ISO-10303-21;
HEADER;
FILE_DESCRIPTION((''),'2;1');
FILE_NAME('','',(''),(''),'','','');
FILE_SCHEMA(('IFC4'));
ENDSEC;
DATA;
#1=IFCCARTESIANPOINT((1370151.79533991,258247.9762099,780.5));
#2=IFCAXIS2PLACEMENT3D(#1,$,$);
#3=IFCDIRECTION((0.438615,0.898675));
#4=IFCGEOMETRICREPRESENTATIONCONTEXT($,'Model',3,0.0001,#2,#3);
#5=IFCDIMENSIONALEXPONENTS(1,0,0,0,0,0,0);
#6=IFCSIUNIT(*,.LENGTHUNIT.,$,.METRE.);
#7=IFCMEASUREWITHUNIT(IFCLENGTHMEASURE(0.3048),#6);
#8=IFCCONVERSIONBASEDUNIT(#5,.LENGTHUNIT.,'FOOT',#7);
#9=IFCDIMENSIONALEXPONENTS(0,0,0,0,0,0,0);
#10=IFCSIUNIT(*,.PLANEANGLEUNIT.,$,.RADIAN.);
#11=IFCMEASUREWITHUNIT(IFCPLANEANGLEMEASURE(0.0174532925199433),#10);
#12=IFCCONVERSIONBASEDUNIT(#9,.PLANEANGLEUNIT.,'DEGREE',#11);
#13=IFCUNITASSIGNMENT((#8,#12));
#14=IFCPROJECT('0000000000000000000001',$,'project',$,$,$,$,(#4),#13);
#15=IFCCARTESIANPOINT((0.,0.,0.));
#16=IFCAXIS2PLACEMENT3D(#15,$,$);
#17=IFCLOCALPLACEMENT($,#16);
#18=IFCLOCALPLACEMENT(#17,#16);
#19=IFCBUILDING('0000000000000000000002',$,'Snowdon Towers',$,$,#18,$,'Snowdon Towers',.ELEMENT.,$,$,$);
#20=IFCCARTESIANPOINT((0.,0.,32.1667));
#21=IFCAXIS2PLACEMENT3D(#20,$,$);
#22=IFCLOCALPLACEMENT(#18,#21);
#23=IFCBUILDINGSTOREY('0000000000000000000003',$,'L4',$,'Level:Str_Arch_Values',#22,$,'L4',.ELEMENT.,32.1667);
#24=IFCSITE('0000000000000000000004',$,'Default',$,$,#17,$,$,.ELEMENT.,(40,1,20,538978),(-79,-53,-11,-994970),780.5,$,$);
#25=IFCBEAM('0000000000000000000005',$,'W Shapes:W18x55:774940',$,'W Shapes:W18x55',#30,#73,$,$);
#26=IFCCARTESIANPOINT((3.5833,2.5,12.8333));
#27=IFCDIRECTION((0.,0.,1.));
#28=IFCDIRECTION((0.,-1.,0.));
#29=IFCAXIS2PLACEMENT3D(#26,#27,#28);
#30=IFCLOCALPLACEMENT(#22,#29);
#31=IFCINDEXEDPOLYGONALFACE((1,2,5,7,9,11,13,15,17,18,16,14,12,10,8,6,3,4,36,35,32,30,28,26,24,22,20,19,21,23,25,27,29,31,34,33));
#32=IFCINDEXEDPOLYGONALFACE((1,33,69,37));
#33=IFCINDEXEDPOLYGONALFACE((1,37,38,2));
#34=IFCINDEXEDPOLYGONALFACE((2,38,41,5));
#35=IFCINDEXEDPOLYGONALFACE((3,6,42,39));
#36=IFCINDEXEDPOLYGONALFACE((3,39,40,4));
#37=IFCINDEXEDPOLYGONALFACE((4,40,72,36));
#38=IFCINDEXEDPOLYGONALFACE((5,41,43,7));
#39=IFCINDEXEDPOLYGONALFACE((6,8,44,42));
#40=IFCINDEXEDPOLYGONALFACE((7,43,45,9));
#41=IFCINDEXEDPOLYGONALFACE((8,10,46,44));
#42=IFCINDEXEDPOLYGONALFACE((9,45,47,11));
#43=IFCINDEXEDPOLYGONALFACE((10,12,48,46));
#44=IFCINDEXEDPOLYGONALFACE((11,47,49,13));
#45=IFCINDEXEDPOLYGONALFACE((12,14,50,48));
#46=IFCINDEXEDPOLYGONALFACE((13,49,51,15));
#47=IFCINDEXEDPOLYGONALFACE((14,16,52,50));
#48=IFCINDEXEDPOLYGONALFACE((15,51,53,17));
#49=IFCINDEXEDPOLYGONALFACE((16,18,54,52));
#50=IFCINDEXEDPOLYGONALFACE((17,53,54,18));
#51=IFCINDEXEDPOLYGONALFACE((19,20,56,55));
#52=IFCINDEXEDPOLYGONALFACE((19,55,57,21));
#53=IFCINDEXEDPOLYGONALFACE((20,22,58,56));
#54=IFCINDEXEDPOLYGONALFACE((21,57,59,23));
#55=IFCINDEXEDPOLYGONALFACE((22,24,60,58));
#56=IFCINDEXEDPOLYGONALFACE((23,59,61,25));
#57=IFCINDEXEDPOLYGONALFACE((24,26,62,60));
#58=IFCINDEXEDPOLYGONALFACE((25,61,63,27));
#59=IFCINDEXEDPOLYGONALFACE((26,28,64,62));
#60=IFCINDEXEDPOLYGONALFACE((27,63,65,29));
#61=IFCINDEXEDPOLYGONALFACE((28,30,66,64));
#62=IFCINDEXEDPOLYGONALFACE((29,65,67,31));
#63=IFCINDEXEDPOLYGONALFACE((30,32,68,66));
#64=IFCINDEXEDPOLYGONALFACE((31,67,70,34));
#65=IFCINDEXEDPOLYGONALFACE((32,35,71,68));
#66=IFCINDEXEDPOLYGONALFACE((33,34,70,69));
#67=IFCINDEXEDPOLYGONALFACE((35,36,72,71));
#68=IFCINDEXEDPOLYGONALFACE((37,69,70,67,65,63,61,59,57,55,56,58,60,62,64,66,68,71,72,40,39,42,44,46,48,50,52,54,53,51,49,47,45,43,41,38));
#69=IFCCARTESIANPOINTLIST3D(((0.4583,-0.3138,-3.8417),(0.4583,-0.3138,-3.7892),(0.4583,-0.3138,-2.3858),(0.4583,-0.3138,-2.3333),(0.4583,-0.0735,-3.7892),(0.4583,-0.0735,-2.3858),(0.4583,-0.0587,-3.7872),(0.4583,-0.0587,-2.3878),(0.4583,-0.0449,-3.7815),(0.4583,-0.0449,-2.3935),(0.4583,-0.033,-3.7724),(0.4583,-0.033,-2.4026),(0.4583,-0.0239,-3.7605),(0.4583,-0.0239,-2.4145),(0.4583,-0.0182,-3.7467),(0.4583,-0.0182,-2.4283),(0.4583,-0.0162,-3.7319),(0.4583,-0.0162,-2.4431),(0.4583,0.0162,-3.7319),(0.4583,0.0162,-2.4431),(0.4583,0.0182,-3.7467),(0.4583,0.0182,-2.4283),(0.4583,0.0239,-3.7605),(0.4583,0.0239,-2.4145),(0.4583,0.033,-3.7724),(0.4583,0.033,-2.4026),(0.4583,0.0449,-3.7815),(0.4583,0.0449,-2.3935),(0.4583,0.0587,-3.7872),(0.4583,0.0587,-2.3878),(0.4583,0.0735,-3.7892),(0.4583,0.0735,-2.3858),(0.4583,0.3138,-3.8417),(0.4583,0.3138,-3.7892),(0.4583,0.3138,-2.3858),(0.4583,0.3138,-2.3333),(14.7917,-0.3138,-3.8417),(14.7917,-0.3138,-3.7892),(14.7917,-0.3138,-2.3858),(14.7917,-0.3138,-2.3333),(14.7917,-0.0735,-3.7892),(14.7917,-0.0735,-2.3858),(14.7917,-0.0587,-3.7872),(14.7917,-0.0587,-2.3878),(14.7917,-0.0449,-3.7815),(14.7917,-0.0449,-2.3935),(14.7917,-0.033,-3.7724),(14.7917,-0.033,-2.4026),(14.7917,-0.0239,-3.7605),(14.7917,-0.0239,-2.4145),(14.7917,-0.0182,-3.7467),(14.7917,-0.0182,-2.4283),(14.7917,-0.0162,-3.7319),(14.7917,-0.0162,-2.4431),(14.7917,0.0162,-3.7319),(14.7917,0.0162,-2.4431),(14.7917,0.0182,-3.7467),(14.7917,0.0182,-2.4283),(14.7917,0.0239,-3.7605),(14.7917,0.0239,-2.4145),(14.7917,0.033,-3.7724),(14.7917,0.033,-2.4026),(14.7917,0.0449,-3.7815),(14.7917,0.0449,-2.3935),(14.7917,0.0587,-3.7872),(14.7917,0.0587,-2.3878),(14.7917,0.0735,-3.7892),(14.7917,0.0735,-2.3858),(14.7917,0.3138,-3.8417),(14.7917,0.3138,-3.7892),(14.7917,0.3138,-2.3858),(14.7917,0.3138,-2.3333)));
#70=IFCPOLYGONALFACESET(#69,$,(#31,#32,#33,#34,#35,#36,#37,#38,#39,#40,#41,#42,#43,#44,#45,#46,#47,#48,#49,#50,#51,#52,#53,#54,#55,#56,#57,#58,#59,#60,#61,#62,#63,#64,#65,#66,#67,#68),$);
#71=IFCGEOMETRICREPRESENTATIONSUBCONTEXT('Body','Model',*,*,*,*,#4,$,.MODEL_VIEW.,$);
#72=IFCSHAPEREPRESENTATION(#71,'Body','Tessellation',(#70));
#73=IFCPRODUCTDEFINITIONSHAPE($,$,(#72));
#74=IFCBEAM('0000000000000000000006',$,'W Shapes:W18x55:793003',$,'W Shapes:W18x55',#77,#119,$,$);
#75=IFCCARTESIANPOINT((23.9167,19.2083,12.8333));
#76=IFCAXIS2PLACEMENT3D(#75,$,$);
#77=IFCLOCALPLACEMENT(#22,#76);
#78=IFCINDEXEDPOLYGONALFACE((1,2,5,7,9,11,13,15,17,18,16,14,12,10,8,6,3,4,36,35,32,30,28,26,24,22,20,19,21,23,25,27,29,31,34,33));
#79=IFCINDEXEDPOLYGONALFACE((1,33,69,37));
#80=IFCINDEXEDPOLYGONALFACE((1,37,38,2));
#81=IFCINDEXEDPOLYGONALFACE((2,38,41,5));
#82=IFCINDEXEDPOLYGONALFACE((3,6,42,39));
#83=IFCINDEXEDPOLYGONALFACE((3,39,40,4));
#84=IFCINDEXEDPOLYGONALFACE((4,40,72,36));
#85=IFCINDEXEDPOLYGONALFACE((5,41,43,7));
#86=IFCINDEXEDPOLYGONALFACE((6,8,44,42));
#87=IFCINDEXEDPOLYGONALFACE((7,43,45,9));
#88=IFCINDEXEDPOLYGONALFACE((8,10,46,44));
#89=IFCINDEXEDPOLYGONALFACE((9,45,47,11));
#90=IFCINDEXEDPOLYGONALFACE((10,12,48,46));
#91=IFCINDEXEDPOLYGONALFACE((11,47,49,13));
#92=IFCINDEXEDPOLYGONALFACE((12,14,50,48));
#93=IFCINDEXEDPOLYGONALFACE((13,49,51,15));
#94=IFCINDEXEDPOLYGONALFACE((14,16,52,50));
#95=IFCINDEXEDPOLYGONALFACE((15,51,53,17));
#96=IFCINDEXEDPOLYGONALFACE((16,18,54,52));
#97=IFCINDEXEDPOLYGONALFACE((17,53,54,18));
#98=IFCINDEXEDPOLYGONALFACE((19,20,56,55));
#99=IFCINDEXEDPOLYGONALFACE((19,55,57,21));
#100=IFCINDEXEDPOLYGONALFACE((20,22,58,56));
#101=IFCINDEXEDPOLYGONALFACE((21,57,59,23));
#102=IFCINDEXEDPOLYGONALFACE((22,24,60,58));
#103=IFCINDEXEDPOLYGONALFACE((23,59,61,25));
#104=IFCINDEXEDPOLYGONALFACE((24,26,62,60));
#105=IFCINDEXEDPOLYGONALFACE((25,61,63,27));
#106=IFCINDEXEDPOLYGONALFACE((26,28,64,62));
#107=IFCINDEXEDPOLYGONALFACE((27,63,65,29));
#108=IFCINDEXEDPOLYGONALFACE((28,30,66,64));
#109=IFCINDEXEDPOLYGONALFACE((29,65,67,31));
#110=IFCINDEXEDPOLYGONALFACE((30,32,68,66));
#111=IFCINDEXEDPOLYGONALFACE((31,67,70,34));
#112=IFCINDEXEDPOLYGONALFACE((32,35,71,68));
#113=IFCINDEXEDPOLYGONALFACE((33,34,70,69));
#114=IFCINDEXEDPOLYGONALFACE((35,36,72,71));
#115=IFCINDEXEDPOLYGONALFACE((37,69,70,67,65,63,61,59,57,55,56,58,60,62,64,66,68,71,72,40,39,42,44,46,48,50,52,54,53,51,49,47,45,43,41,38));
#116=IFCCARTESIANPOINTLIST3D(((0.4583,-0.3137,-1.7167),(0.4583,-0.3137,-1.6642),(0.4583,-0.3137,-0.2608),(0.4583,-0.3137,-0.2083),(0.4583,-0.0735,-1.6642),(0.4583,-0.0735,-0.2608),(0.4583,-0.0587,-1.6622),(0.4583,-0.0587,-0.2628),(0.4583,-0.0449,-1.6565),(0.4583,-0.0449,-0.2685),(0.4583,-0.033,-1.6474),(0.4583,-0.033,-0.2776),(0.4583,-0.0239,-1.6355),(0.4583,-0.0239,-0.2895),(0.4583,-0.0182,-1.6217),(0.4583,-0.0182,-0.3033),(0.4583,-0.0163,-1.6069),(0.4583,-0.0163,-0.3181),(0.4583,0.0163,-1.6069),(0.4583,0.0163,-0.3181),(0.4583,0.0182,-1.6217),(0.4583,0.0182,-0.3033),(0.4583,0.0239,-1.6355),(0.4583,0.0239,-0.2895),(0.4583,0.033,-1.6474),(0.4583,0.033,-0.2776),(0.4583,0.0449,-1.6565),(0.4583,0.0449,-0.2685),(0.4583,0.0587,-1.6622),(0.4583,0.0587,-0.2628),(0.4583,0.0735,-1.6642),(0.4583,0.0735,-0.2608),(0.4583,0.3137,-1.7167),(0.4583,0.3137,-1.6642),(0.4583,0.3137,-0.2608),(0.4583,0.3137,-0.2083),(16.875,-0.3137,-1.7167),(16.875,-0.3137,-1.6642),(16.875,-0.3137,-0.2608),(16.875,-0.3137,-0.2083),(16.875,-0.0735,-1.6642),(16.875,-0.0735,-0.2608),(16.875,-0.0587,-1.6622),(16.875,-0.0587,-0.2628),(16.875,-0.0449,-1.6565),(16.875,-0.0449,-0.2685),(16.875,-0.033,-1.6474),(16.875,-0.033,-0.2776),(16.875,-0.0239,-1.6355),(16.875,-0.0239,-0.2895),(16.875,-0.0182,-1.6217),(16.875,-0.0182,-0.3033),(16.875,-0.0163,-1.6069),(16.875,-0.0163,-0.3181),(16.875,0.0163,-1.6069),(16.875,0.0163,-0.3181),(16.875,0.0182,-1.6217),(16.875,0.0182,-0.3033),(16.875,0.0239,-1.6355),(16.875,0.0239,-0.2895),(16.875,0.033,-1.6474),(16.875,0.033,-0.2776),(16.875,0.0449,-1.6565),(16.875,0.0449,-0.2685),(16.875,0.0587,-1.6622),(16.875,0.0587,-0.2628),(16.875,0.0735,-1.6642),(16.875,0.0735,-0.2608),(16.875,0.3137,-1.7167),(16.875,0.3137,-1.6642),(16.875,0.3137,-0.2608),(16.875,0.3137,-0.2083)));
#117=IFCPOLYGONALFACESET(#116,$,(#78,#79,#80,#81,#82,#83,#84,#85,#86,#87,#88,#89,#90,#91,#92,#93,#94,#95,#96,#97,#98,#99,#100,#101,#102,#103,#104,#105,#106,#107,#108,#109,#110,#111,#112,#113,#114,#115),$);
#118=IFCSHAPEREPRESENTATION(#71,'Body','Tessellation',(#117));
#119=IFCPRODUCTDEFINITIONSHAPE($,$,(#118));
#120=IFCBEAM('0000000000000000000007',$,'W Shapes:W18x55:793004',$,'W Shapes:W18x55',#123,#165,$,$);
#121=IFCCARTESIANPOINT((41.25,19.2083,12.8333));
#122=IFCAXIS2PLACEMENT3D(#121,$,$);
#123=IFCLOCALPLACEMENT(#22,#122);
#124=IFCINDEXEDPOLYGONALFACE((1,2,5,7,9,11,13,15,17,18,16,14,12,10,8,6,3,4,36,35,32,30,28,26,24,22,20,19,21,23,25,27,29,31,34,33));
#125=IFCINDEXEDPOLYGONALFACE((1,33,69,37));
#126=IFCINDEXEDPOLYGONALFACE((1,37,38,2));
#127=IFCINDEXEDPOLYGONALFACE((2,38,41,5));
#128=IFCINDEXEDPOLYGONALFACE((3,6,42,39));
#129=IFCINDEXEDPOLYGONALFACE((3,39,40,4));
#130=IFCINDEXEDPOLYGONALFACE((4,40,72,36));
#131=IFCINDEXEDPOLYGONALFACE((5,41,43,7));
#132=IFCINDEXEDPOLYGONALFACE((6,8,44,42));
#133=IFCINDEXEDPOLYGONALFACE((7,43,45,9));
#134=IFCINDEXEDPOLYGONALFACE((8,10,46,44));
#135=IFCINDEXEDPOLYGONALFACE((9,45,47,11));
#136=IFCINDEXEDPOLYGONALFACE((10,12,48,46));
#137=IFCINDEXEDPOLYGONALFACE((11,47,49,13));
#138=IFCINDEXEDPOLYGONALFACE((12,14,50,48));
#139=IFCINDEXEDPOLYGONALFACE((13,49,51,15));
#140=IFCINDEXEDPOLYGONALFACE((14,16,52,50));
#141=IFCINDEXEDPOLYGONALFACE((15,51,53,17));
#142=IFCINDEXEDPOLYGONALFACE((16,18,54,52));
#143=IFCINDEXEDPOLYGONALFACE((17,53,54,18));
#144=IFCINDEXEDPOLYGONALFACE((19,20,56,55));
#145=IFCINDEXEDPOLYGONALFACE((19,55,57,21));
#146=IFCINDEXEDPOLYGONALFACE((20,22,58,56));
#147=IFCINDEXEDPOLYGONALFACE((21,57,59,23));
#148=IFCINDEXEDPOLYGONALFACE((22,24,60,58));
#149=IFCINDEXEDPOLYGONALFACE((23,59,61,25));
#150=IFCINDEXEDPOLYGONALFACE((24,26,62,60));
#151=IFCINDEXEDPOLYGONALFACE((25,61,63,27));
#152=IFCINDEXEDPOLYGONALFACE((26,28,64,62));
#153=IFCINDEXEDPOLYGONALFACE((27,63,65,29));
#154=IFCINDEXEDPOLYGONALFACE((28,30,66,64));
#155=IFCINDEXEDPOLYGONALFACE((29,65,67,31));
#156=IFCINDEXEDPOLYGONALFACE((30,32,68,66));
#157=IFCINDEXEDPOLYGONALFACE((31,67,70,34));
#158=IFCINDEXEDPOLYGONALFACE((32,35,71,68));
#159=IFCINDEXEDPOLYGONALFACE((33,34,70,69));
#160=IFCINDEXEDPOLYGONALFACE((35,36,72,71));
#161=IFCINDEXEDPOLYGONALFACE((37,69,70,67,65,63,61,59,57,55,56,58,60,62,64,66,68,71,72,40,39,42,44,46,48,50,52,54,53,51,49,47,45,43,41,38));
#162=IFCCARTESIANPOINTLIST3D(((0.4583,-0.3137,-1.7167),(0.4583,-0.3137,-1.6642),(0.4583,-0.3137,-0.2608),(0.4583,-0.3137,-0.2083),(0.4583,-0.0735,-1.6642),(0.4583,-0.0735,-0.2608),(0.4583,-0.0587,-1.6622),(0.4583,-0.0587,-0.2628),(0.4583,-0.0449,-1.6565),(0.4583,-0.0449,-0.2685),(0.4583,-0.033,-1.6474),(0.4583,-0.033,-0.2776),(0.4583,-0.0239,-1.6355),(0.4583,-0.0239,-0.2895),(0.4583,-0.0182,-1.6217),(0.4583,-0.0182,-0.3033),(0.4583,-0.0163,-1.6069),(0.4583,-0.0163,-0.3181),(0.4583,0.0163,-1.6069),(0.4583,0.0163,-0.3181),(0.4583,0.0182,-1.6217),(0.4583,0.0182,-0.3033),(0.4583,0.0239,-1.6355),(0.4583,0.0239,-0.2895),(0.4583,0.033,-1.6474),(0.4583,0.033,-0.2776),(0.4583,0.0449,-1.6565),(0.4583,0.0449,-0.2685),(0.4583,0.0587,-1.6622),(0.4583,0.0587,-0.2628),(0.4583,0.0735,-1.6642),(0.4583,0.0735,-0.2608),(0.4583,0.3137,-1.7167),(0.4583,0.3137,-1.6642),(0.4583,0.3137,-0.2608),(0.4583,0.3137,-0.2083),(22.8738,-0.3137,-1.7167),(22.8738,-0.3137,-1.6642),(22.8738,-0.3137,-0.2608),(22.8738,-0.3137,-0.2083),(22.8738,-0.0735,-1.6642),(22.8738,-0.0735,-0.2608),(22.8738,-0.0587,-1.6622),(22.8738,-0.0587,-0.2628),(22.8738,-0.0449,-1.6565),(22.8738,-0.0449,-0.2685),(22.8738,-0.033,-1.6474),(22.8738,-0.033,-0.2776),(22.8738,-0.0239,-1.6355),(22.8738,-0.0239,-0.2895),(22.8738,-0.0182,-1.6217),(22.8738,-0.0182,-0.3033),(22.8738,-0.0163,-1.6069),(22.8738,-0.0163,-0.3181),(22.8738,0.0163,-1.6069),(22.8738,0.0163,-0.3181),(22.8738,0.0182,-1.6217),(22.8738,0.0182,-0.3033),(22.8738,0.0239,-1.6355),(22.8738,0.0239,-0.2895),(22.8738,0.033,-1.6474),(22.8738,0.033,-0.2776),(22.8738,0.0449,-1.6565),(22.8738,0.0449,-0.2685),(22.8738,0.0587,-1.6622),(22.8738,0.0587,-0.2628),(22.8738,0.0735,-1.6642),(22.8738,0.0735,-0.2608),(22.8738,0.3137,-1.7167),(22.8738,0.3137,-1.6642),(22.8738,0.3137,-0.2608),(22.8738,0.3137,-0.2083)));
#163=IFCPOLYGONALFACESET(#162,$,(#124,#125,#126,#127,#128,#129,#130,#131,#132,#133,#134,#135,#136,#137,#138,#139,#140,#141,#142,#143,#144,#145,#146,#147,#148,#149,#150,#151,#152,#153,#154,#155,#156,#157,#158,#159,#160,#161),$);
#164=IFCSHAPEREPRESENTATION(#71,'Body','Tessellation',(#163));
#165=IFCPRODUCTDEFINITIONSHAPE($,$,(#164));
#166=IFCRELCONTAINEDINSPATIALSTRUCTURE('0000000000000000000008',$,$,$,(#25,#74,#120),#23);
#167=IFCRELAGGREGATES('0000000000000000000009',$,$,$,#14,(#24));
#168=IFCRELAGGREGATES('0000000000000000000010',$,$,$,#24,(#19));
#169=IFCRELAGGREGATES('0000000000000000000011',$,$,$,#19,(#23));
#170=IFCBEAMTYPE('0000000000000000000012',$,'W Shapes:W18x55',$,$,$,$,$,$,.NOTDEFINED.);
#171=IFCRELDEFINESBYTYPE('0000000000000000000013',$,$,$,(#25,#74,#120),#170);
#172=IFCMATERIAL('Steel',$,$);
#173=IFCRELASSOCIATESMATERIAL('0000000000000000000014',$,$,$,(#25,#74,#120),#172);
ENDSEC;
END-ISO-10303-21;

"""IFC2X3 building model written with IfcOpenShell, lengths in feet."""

from ifc_helpers import new_model, entity, si_unit, converted_unit, direction, frame, frame_2d, origin, place, context, subcontext, project, spatial, i_section, extrude, material, type_object, element, save


model = new_model("IFC2X3")

# Units and contexts
model_context = context("Model", 3, precision=0.0001, world=frame((1370151.79533991, 258247.9762099, 780.5)), true_north=direction((0.438615, 0.898675)))
body_context = subcontext(model_context, "Body", "Model", "MODEL_VIEW")
ifc_project = project(units=[converted_unit("LENGTHUNIT", "FOOT", entity("IfcLengthMeasure", 0.3048), si_unit("LENGTHUNIT", "METRE"), dimensions=[1, 0, 0, 0, 0, 0, 0]), converted_unit("PLANEANGLEUNIT", "DEGREE", entity("IfcPlaneAngleMeasure", 0.0174532925199433), si_unit("PLANEANGLEUNIT", "RADIAN"), dimensions=[0, 0, 0, 0, 0, 0, 0])], contexts=[model_context])

# Site, building, storey
site_placement = place(None, origin())
site = spatial("IfcSite", under=ifc_project, at=site_placement, Name="Default", CompositionType="ELEMENT", RefLatitude=(40, 1, 20, 538978), RefLongitude=(-79, -53, -11, -994970), RefElevation=780.5)
building_placement = place(site_placement, origin())
building = spatial("IfcBuilding", under=site, at=building_placement, Name="Snowdon Towers", LongName="Snowdon Towers", CompositionType="ELEMENT")
storey_placement = place(building_placement, frame((0.0, 0.0, 32.1667)))
storey = spatial("IfcBuildingStorey", under=building, at=storey_placement, Name="L4", ObjectType="Level:Str_Arch_Values", LongName="L4", CompositionType="ELEMENT", Elevation=32.1667)

# Beams
ifc_material = material(Name="Steel")
beam_type_1 = type_object("IfcBeamType", Name="W Shapes:W18x55", PredefinedType="NOTDEFINED")
beam_1_placement = place(storey_placement, frame((3.5833, 2.5, 12.8333), z_axis=(0.0, 0.0, 1.0), x_axis=(0.0, -1.0, 0.0)))
element("IfcBeam", 1, at=beam_1_placement, inside=storey, type_object=beam_type_1, material=ifc_material, Name="W Shapes:W18x55:774940", ObjectType="W Shapes:W18x55", context=body_context, shape_type="SweptSolid", body=[
    extrude(i_section(OverallWidth=0.6275, OverallDepth=1.5083, WebThickness=0.0325, FlangeThickness=0.0525, FilletRadius=0.0573, at=frame_2d((0.0, 0.0), x_axis=(0.0, 1.0))), frame((0.4583, 0.0, -3.0875), z_axis=(1.0, 0.0, 0.0), x_axis=(0.0, 0.0, -1.0)), (0.0, 0.0, 1.0), 14.3333),
])
beam_2_placement = place(storey_placement, frame((23.9167, 19.2083, 12.8333)))
element("IfcBeam", 2, at=beam_2_placement, inside=storey, type_object=beam_type_1, material=ifc_material, Name="W Shapes:W18x55:793003", ObjectType="W Shapes:W18x55", context=body_context, shape_type="SweptSolid", body=[
    extrude(i_section(OverallWidth=0.6275, OverallDepth=1.5083, WebThickness=0.0325, FlangeThickness=0.0525, FilletRadius=0.0573, at=frame_2d((0.0, 0.0), x_axis=(0.0, 1.0))), frame((0.4583, 0.0, -0.9625), z_axis=(1.0, 0.0, 0.0), x_axis=(0.0, 0.0, -1.0)), (0.0, 0.0, 1.0), 16.4167),
])
beam_3_placement = place(storey_placement, frame((41.25, 19.2083, 12.8333)))
element("IfcBeam", 3, at=beam_3_placement, inside=storey, type_object=beam_type_1, material=ifc_material, Name="W Shapes:W18x55:793004", ObjectType="W Shapes:W18x55", context=body_context, shape_type="SweptSolid", body=[
    extrude(i_section(OverallWidth=0.6275, OverallDepth=1.5083, WebThickness=0.0325, FlangeThickness=0.0525, FilletRadius=0.0573, at=frame_2d((0.0, 0.0), x_axis=(0.0, 1.0))), frame((0.4583, 0.0, -0.9625), z_axis=(1.0, 0.0, 0.0), x_axis=(0.0, 0.0, -1.0)), (0.0, 0.0, 1.0), 22.4154),
])

save(model, "model.ifc")
